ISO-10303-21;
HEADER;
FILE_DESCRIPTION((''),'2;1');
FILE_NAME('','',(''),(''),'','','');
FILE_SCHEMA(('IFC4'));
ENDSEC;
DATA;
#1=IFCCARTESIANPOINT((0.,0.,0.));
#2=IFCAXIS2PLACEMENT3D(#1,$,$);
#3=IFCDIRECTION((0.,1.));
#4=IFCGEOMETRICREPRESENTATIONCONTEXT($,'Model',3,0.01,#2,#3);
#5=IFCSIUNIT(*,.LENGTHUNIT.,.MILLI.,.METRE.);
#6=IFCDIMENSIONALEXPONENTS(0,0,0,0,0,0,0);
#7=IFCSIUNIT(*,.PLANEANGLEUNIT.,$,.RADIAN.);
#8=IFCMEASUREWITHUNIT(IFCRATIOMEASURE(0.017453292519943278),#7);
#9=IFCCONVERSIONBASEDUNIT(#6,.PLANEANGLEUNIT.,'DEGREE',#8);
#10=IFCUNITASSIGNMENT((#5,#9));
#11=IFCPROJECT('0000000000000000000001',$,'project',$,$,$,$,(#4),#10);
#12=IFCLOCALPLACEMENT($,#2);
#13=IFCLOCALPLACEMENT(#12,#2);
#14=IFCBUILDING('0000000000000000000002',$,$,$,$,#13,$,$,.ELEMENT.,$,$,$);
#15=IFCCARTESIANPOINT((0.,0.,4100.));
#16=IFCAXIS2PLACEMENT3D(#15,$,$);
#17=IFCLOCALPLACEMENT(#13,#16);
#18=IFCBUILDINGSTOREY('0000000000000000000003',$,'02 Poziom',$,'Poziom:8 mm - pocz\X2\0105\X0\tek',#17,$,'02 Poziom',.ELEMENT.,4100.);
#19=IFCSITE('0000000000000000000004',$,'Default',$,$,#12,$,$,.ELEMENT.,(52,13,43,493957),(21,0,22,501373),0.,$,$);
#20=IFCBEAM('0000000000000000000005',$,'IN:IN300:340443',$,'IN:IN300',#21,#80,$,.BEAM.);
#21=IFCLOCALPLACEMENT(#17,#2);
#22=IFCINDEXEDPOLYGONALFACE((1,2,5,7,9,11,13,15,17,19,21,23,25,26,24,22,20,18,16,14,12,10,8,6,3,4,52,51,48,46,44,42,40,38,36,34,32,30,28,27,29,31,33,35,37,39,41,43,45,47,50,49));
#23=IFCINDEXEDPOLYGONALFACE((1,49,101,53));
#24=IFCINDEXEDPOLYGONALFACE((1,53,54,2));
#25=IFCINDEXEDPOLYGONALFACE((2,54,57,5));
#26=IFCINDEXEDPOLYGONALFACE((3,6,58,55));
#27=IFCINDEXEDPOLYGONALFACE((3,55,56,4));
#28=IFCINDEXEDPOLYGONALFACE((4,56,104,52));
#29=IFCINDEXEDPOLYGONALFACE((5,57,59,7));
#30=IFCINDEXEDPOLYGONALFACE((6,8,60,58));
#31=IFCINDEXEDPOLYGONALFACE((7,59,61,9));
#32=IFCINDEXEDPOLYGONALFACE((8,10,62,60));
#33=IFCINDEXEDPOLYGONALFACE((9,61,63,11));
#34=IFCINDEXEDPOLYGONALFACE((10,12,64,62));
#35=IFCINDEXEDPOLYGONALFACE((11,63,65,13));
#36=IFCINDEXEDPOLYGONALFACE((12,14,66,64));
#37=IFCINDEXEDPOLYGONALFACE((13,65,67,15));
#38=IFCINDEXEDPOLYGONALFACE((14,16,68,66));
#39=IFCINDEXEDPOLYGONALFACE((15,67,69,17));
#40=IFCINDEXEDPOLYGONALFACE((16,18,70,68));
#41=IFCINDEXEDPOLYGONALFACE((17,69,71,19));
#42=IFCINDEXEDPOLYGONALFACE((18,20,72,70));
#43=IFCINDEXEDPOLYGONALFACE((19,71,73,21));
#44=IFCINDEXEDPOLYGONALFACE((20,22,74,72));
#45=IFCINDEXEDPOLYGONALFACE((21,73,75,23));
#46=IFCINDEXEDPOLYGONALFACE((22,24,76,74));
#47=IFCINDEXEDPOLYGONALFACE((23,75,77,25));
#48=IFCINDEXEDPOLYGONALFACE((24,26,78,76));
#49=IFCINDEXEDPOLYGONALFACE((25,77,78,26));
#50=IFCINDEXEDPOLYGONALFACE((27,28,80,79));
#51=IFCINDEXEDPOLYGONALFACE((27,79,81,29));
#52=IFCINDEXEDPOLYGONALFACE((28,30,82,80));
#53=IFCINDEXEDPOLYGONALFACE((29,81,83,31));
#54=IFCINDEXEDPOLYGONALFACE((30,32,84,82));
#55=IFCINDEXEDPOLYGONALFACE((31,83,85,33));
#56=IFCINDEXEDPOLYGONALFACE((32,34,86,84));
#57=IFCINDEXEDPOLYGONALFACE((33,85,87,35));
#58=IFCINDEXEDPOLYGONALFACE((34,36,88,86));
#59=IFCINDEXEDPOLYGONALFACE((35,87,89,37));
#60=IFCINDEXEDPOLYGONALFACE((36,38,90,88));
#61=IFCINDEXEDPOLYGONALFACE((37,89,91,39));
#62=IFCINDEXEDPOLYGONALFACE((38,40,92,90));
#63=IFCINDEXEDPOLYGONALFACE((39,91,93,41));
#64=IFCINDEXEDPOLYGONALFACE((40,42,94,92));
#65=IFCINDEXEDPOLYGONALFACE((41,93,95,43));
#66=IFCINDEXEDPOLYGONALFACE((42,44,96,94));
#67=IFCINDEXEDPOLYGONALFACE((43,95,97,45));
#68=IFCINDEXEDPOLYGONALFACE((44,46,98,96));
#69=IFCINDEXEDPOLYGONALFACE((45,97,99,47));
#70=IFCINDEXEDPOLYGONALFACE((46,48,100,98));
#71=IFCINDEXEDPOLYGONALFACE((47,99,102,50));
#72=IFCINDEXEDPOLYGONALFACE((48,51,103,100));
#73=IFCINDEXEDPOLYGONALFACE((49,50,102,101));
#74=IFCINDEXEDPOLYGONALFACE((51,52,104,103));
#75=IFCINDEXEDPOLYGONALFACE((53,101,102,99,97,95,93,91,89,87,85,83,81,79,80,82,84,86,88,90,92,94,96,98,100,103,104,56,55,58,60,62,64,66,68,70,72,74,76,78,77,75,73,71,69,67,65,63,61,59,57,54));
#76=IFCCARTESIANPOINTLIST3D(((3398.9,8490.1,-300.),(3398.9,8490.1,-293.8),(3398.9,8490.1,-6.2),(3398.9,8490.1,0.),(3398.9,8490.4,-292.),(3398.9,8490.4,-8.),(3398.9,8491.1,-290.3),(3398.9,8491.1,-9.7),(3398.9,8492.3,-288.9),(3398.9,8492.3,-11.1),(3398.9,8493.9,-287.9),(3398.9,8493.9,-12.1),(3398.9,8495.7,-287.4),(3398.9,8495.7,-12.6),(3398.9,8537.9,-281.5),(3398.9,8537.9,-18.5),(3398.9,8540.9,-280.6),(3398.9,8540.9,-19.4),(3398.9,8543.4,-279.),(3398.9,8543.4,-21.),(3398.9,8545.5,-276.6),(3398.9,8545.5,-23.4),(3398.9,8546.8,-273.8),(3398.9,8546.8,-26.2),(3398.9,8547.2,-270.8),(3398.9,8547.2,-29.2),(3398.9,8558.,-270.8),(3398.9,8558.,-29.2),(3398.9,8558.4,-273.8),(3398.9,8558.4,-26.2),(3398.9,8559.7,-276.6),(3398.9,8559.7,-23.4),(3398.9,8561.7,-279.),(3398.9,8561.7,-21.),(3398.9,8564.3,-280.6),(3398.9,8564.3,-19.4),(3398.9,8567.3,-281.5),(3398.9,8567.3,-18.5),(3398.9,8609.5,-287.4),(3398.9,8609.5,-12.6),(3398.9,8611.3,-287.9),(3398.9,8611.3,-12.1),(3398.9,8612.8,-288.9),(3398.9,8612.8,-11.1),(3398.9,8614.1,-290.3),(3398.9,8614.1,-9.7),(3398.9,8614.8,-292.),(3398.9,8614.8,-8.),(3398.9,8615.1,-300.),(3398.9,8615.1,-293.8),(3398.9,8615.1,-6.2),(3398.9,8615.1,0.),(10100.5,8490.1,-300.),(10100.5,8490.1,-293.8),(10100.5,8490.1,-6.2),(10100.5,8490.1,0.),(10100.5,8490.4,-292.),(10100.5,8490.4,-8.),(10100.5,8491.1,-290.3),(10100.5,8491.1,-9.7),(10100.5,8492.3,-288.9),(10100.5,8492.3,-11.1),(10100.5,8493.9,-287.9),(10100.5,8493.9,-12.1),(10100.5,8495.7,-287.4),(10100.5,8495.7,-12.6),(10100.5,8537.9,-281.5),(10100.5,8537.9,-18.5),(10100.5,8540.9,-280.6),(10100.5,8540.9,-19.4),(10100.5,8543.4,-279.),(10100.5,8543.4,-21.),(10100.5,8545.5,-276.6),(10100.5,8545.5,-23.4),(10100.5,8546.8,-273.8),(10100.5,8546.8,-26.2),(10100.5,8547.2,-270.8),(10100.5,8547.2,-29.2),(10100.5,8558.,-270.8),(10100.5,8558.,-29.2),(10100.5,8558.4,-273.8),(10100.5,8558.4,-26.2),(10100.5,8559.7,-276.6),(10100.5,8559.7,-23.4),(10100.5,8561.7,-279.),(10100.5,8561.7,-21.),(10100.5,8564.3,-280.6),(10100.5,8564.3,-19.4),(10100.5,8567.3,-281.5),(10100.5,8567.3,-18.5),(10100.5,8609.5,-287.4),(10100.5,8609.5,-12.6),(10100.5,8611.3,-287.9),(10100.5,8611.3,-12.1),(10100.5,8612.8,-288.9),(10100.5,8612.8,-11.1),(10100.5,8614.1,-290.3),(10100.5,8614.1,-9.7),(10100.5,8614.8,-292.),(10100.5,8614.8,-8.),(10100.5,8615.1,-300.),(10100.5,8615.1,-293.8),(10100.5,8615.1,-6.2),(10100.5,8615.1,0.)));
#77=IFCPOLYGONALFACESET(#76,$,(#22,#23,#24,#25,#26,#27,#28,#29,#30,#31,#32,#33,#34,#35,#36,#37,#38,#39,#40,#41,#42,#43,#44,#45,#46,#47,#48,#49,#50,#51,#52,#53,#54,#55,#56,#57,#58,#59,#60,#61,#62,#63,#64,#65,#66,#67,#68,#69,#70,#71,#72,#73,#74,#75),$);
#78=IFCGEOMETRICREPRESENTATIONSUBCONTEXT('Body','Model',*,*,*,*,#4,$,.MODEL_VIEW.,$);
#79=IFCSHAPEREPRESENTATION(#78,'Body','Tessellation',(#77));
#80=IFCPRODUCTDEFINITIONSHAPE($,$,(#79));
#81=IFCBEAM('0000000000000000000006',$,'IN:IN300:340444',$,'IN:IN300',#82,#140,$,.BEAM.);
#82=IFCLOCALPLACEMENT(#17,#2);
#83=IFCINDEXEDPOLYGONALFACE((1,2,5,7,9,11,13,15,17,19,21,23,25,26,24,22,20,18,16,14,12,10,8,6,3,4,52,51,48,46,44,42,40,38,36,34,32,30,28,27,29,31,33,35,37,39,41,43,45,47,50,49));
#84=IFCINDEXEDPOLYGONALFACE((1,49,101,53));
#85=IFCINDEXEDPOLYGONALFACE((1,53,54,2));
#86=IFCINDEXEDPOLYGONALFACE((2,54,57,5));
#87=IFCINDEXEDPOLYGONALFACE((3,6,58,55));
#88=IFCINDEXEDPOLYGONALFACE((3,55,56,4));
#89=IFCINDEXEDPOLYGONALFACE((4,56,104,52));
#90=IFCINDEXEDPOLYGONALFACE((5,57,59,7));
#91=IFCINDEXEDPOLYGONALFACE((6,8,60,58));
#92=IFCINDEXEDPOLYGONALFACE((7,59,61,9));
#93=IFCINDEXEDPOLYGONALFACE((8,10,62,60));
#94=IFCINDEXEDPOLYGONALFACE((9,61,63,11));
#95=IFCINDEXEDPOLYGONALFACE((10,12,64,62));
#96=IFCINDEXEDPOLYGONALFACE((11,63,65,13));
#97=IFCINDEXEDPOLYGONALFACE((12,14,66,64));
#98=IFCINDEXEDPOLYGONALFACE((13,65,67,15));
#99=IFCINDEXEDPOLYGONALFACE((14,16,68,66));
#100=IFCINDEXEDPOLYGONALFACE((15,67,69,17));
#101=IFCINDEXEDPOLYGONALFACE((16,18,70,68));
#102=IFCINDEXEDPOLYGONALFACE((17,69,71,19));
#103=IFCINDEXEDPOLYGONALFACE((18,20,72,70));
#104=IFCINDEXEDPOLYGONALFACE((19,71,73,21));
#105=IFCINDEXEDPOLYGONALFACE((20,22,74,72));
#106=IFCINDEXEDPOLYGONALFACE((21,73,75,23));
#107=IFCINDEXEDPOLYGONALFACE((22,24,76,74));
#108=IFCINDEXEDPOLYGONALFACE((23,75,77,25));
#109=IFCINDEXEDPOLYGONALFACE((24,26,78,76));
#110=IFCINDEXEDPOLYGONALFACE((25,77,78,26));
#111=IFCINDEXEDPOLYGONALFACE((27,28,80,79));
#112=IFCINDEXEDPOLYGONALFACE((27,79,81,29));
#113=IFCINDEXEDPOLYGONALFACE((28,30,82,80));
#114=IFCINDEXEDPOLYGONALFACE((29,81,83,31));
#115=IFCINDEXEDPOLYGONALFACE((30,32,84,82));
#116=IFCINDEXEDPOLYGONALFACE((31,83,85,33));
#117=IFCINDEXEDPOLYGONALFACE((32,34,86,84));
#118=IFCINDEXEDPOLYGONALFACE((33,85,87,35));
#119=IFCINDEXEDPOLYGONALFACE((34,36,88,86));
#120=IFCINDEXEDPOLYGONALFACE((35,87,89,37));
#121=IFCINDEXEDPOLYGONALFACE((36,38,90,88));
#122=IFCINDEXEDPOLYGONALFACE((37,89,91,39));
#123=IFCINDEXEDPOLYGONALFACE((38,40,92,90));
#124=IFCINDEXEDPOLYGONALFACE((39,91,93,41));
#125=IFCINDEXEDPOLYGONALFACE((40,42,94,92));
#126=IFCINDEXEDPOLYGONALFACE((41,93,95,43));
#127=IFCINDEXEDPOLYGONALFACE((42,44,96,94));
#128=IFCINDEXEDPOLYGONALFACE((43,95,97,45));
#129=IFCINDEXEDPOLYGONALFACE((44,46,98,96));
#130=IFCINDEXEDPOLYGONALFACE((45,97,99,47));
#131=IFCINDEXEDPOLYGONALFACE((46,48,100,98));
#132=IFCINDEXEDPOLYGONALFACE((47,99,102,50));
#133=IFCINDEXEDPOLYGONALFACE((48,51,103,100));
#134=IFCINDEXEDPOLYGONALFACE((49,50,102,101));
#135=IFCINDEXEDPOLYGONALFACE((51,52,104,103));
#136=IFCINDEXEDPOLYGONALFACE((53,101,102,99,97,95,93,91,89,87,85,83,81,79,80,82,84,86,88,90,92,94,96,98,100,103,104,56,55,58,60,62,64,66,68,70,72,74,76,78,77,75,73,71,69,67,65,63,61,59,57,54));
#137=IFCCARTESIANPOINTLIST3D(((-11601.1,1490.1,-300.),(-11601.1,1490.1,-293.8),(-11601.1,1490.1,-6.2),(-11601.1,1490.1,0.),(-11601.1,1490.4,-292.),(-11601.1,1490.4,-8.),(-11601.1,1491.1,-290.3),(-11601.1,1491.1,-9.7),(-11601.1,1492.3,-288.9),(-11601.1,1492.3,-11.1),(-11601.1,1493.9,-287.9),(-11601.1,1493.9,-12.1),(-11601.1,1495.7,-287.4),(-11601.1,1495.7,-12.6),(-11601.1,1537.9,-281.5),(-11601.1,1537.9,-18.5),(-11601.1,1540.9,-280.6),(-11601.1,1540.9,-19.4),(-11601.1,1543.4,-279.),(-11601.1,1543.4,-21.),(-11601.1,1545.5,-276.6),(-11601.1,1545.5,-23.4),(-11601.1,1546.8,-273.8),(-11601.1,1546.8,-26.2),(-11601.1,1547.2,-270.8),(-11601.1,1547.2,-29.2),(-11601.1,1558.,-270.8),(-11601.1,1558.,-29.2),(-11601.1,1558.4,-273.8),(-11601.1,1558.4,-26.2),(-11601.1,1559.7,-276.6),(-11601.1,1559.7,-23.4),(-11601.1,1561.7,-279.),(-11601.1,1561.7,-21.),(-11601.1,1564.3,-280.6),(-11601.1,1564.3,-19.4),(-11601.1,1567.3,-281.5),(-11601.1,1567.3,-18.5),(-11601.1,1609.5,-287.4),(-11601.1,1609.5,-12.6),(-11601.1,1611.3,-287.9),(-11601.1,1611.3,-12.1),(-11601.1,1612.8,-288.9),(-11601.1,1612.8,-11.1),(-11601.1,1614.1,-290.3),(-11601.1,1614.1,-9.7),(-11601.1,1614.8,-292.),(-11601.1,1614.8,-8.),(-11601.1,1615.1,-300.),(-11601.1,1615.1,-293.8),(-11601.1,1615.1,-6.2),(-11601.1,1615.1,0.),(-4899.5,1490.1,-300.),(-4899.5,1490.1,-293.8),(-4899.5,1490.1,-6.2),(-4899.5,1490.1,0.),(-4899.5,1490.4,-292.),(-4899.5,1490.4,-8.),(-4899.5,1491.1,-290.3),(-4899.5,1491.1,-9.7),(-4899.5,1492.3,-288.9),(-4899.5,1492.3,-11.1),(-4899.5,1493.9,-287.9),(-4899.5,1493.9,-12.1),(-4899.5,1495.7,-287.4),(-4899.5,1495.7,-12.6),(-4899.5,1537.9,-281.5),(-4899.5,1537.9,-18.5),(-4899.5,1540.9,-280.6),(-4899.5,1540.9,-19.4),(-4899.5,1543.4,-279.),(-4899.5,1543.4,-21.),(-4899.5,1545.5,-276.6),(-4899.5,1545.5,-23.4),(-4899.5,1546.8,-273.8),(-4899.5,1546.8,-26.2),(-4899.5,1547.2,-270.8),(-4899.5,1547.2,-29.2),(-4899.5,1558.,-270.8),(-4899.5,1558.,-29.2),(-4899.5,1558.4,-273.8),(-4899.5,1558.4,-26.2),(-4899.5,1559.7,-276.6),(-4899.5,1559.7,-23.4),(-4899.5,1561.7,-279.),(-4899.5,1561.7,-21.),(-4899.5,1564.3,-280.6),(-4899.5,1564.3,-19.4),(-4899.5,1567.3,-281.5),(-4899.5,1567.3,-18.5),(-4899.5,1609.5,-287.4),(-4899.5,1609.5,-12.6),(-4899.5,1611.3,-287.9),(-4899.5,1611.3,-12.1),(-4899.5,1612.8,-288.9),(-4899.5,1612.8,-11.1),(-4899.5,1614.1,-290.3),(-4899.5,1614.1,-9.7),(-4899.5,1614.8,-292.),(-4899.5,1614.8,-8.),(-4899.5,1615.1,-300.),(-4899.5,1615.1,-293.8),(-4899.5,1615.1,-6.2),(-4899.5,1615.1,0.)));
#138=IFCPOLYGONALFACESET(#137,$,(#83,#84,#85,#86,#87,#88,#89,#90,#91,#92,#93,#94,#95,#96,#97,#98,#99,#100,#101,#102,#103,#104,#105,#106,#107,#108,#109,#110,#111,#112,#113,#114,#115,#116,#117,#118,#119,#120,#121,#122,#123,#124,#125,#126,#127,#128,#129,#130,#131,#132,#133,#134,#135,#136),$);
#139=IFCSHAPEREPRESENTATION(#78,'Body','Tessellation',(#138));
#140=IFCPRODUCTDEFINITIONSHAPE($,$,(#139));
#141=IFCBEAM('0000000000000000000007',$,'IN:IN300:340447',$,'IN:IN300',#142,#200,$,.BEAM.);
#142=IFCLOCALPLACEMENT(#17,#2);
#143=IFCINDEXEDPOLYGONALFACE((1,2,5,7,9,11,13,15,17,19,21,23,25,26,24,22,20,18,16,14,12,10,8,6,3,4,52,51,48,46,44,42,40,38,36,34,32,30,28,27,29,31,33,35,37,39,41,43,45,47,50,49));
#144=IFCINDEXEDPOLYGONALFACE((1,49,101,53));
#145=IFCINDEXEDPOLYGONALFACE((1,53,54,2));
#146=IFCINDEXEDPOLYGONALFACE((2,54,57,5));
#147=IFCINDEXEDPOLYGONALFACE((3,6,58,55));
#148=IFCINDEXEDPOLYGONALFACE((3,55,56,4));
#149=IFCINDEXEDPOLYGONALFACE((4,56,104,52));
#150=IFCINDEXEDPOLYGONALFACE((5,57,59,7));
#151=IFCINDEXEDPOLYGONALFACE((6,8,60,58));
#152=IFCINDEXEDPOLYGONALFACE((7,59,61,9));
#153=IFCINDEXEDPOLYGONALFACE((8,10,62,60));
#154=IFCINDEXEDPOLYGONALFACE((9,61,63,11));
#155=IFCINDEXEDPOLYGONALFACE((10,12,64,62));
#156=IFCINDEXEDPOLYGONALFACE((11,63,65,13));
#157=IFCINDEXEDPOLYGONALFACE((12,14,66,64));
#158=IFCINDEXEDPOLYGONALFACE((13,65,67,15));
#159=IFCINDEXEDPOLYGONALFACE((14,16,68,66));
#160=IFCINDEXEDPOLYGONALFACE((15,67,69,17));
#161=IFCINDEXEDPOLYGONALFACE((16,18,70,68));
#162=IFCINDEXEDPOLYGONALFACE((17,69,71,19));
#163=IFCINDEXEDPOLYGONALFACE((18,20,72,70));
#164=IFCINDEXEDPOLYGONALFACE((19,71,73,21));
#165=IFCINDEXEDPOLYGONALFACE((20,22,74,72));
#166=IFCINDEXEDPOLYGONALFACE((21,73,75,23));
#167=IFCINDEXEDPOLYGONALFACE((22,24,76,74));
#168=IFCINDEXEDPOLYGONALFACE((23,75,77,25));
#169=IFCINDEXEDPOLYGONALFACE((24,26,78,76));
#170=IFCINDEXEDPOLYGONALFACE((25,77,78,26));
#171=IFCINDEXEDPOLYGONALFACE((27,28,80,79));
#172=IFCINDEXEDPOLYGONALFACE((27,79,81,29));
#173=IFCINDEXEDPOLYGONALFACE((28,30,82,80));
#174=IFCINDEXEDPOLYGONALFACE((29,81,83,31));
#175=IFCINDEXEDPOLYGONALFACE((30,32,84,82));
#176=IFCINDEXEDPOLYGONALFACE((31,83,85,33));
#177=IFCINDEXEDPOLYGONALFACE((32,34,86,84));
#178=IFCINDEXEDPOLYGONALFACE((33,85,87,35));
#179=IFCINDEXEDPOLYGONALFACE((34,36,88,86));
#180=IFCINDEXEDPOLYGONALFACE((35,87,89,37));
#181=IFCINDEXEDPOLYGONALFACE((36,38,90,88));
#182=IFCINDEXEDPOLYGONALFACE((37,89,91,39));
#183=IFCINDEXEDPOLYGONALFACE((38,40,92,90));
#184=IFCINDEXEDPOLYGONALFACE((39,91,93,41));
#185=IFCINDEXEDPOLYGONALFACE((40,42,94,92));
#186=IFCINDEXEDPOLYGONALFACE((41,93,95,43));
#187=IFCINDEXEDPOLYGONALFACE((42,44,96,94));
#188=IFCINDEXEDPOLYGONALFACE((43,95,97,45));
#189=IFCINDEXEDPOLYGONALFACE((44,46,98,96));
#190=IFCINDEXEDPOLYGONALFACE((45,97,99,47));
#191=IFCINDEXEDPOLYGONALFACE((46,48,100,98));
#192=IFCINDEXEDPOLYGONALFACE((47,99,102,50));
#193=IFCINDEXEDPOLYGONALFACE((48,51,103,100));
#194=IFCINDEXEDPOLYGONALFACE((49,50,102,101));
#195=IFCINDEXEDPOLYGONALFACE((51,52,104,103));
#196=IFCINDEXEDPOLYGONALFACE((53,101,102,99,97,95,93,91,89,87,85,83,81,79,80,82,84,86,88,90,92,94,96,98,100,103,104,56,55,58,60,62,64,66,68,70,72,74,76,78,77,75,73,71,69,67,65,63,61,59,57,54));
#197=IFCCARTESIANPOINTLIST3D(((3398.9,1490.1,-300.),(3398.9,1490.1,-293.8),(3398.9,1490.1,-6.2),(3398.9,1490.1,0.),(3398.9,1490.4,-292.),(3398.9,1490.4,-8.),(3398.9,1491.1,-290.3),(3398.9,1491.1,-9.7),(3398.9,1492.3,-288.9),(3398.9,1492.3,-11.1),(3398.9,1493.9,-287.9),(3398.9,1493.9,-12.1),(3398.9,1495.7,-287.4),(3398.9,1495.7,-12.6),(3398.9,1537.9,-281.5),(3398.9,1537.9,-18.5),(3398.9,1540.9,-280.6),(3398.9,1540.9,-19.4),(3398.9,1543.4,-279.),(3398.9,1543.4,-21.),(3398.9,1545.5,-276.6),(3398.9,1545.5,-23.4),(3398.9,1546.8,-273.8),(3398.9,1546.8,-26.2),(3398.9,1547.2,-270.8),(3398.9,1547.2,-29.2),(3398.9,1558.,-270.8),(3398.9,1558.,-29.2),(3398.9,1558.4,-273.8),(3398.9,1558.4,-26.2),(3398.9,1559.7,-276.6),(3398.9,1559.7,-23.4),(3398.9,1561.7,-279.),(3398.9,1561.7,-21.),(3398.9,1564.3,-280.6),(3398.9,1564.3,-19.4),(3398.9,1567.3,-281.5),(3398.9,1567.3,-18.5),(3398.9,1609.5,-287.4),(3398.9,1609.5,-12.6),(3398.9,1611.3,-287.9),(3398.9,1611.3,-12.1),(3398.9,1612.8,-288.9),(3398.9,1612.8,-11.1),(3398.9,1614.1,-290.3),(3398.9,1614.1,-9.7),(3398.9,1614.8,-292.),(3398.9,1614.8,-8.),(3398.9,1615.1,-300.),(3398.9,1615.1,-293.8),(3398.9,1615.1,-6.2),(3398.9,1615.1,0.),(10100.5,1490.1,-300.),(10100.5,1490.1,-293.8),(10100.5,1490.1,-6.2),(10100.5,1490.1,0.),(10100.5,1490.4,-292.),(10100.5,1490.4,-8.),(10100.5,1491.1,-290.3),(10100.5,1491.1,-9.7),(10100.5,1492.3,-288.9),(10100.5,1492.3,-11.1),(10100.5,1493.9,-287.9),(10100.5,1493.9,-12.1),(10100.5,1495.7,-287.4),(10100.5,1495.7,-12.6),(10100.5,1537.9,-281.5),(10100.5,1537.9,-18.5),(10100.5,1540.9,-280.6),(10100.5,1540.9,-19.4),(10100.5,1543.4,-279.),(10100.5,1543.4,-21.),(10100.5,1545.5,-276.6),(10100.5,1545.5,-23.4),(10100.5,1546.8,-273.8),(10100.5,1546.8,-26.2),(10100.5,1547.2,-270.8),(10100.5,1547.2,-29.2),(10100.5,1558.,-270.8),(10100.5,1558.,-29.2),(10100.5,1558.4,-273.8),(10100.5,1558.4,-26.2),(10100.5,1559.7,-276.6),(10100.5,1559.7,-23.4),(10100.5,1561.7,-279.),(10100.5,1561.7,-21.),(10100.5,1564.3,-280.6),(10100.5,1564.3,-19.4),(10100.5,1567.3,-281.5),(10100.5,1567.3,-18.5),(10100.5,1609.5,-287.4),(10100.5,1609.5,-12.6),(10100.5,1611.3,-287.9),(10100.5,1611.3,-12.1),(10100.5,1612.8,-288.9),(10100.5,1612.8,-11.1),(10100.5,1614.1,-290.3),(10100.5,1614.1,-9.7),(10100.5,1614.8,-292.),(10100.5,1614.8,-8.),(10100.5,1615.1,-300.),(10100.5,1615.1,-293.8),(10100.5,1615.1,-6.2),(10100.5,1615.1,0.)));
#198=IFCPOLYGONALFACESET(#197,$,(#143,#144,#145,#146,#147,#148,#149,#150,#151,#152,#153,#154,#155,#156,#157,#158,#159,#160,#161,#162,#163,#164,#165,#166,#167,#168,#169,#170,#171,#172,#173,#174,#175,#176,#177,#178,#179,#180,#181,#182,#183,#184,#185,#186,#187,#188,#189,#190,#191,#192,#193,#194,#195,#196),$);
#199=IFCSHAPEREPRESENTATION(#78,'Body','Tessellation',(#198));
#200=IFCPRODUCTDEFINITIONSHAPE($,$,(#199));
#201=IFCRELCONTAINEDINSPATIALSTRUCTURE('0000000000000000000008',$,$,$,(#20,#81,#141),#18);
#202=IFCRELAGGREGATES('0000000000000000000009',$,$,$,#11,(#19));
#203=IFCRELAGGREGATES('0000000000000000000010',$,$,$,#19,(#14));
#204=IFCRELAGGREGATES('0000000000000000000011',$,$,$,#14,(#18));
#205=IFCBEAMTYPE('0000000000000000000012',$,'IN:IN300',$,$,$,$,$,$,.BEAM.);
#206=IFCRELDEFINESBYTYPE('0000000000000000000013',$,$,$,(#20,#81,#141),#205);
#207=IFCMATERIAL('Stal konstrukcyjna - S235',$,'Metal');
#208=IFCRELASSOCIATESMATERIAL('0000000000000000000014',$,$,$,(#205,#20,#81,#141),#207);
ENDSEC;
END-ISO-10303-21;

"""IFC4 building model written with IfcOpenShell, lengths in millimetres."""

from ifc_helpers import new_model, entity, si_unit, converted_unit, direction, frame, origin, place, context, subcontext, project, spatial, line, arc, indexed_curve, outline, extrude, source, transform, mapped, material, type_object, type_shapes, element, save


model = new_model("IFC4")

# Units and contexts
model_context = context("Model", 3, precision=0.01, world=origin(), true_north=direction((0.0, 1.0)))
body_context = subcontext(model_context, "Body", "Model", "MODEL_VIEW")
ifc_project = project(units=[si_unit("LENGTHUNIT", "METRE", prefix="MILLI"), converted_unit("PLANEANGLEUNIT", "DEGREE", entity("IfcRatioMeasure", 0.017453292519943278), si_unit("PLANEANGLEUNIT", "RADIAN"), dimensions=[0, 0, 0, 0, 0, 0, 0])], contexts=[model_context])

# Site, building, storey
site_placement = place(None, origin())
site = spatial("IfcSite", under=ifc_project, at=site_placement, Name="Default", CompositionType="ELEMENT", RefLatitude=(52, 13, 43, 493957), RefLongitude=(21, 0, 22, 501373), RefElevation=0.0)
building_placement = place(site_placement, origin())
building = spatial("IfcBuilding", under=site, at=building_placement, CompositionType="ELEMENT")
storey_placement = place(building_placement, frame((0.0, 0.0, 4100.0)))
storey = spatial("IfcBuildingStorey", under=building, at=storey_placement, Name="02 Poziom", ObjectType="Poziom:8 mm - początek", LongName="02 Poziom", CompositionType="ELEMENT", Elevation=4100.0)

# Shared definitions
ifc_material_1 = material(Name="Stal konstrukcyjna - S235", Category="Metal")

# Beams
beam_type_1 = type_object("IfcBeamType", Name="IN:IN300", PredefinedType="BEAM", material=ifc_material_1)
shared_shape_1 = source(origin(), body_context, "Body", "SweptSolid", [
    extrude(outline(indexed_curve([(143.8, -62.5), (150.0, -62.5), (150.0, 62.5), (143.8, 62.5), (139.6, 60.9), (137.4, 56.9), (131.5, 14.7), (127.9, 8.1), (120.8, 5.4), (-120.8, 5.4), (-127.9, 8.1), (-131.5, 14.7), (-137.4, 56.9), (-139.6, 60.9), (-143.8, 62.5), (-150.0, 62.5), (-150.0, -62.5), (-143.8, -62.5), (-139.6, -60.9), (-137.4, -56.9), (-131.5, -14.7), (-127.9, -8.1), (-120.8, -5.4), (120.8, -5.4), (127.9, -8.1), (131.5, -14.7), (137.4, -56.9), (139.6, -60.9)], segments=[line(1, 2, 3, 4), arc(4, 5, 6), line(6, 7), arc(7, 8, 9), line(9, 10), arc(10, 11, 12), line(12, 13), arc(13, 14, 15), line(15, 16, 17, 18), arc(18, 19, 20), line(20, 21), arc(21, 22, 23), line(23, 24), arc(24, 25, 26), line(26, 27), arc(27, 28, 1)], self_intersect=False)), frame((-3350.8, 0.0, 0.0), z_axis=(1.0, 0.0, 0.0), x_axis=(0.0, 0.0, -1.0)), (0.0, 0.0, 1.0), 6701.6),
])
type_shapes(beam_type_1, [shared_shape_1])
for number, where, name in (
    (1, (6749.7, 8552.6, -150.0), "IN:IN300:340443"),
    (2, (-8250.3, 1552.6, -150.0), "IN:IN300:340444"),
    (3, (6749.7, 1552.6, -150.0), "IN:IN300:340447"),
):
    element("IfcBeam", number, at=place(storey_placement, frame(where)), inside=storey, type_object=beam_type_1, material=ifc_material_1, Name=name, ObjectType="IN:IN300", PredefinedType="BEAM", context=body_context, shape_type="MappedRepresentation", body=[
        mapped(shared_shape_1, transform((0.0, 0.0, 0.0), scale=1.0)),
    ])

save(model, "model.ifc")
